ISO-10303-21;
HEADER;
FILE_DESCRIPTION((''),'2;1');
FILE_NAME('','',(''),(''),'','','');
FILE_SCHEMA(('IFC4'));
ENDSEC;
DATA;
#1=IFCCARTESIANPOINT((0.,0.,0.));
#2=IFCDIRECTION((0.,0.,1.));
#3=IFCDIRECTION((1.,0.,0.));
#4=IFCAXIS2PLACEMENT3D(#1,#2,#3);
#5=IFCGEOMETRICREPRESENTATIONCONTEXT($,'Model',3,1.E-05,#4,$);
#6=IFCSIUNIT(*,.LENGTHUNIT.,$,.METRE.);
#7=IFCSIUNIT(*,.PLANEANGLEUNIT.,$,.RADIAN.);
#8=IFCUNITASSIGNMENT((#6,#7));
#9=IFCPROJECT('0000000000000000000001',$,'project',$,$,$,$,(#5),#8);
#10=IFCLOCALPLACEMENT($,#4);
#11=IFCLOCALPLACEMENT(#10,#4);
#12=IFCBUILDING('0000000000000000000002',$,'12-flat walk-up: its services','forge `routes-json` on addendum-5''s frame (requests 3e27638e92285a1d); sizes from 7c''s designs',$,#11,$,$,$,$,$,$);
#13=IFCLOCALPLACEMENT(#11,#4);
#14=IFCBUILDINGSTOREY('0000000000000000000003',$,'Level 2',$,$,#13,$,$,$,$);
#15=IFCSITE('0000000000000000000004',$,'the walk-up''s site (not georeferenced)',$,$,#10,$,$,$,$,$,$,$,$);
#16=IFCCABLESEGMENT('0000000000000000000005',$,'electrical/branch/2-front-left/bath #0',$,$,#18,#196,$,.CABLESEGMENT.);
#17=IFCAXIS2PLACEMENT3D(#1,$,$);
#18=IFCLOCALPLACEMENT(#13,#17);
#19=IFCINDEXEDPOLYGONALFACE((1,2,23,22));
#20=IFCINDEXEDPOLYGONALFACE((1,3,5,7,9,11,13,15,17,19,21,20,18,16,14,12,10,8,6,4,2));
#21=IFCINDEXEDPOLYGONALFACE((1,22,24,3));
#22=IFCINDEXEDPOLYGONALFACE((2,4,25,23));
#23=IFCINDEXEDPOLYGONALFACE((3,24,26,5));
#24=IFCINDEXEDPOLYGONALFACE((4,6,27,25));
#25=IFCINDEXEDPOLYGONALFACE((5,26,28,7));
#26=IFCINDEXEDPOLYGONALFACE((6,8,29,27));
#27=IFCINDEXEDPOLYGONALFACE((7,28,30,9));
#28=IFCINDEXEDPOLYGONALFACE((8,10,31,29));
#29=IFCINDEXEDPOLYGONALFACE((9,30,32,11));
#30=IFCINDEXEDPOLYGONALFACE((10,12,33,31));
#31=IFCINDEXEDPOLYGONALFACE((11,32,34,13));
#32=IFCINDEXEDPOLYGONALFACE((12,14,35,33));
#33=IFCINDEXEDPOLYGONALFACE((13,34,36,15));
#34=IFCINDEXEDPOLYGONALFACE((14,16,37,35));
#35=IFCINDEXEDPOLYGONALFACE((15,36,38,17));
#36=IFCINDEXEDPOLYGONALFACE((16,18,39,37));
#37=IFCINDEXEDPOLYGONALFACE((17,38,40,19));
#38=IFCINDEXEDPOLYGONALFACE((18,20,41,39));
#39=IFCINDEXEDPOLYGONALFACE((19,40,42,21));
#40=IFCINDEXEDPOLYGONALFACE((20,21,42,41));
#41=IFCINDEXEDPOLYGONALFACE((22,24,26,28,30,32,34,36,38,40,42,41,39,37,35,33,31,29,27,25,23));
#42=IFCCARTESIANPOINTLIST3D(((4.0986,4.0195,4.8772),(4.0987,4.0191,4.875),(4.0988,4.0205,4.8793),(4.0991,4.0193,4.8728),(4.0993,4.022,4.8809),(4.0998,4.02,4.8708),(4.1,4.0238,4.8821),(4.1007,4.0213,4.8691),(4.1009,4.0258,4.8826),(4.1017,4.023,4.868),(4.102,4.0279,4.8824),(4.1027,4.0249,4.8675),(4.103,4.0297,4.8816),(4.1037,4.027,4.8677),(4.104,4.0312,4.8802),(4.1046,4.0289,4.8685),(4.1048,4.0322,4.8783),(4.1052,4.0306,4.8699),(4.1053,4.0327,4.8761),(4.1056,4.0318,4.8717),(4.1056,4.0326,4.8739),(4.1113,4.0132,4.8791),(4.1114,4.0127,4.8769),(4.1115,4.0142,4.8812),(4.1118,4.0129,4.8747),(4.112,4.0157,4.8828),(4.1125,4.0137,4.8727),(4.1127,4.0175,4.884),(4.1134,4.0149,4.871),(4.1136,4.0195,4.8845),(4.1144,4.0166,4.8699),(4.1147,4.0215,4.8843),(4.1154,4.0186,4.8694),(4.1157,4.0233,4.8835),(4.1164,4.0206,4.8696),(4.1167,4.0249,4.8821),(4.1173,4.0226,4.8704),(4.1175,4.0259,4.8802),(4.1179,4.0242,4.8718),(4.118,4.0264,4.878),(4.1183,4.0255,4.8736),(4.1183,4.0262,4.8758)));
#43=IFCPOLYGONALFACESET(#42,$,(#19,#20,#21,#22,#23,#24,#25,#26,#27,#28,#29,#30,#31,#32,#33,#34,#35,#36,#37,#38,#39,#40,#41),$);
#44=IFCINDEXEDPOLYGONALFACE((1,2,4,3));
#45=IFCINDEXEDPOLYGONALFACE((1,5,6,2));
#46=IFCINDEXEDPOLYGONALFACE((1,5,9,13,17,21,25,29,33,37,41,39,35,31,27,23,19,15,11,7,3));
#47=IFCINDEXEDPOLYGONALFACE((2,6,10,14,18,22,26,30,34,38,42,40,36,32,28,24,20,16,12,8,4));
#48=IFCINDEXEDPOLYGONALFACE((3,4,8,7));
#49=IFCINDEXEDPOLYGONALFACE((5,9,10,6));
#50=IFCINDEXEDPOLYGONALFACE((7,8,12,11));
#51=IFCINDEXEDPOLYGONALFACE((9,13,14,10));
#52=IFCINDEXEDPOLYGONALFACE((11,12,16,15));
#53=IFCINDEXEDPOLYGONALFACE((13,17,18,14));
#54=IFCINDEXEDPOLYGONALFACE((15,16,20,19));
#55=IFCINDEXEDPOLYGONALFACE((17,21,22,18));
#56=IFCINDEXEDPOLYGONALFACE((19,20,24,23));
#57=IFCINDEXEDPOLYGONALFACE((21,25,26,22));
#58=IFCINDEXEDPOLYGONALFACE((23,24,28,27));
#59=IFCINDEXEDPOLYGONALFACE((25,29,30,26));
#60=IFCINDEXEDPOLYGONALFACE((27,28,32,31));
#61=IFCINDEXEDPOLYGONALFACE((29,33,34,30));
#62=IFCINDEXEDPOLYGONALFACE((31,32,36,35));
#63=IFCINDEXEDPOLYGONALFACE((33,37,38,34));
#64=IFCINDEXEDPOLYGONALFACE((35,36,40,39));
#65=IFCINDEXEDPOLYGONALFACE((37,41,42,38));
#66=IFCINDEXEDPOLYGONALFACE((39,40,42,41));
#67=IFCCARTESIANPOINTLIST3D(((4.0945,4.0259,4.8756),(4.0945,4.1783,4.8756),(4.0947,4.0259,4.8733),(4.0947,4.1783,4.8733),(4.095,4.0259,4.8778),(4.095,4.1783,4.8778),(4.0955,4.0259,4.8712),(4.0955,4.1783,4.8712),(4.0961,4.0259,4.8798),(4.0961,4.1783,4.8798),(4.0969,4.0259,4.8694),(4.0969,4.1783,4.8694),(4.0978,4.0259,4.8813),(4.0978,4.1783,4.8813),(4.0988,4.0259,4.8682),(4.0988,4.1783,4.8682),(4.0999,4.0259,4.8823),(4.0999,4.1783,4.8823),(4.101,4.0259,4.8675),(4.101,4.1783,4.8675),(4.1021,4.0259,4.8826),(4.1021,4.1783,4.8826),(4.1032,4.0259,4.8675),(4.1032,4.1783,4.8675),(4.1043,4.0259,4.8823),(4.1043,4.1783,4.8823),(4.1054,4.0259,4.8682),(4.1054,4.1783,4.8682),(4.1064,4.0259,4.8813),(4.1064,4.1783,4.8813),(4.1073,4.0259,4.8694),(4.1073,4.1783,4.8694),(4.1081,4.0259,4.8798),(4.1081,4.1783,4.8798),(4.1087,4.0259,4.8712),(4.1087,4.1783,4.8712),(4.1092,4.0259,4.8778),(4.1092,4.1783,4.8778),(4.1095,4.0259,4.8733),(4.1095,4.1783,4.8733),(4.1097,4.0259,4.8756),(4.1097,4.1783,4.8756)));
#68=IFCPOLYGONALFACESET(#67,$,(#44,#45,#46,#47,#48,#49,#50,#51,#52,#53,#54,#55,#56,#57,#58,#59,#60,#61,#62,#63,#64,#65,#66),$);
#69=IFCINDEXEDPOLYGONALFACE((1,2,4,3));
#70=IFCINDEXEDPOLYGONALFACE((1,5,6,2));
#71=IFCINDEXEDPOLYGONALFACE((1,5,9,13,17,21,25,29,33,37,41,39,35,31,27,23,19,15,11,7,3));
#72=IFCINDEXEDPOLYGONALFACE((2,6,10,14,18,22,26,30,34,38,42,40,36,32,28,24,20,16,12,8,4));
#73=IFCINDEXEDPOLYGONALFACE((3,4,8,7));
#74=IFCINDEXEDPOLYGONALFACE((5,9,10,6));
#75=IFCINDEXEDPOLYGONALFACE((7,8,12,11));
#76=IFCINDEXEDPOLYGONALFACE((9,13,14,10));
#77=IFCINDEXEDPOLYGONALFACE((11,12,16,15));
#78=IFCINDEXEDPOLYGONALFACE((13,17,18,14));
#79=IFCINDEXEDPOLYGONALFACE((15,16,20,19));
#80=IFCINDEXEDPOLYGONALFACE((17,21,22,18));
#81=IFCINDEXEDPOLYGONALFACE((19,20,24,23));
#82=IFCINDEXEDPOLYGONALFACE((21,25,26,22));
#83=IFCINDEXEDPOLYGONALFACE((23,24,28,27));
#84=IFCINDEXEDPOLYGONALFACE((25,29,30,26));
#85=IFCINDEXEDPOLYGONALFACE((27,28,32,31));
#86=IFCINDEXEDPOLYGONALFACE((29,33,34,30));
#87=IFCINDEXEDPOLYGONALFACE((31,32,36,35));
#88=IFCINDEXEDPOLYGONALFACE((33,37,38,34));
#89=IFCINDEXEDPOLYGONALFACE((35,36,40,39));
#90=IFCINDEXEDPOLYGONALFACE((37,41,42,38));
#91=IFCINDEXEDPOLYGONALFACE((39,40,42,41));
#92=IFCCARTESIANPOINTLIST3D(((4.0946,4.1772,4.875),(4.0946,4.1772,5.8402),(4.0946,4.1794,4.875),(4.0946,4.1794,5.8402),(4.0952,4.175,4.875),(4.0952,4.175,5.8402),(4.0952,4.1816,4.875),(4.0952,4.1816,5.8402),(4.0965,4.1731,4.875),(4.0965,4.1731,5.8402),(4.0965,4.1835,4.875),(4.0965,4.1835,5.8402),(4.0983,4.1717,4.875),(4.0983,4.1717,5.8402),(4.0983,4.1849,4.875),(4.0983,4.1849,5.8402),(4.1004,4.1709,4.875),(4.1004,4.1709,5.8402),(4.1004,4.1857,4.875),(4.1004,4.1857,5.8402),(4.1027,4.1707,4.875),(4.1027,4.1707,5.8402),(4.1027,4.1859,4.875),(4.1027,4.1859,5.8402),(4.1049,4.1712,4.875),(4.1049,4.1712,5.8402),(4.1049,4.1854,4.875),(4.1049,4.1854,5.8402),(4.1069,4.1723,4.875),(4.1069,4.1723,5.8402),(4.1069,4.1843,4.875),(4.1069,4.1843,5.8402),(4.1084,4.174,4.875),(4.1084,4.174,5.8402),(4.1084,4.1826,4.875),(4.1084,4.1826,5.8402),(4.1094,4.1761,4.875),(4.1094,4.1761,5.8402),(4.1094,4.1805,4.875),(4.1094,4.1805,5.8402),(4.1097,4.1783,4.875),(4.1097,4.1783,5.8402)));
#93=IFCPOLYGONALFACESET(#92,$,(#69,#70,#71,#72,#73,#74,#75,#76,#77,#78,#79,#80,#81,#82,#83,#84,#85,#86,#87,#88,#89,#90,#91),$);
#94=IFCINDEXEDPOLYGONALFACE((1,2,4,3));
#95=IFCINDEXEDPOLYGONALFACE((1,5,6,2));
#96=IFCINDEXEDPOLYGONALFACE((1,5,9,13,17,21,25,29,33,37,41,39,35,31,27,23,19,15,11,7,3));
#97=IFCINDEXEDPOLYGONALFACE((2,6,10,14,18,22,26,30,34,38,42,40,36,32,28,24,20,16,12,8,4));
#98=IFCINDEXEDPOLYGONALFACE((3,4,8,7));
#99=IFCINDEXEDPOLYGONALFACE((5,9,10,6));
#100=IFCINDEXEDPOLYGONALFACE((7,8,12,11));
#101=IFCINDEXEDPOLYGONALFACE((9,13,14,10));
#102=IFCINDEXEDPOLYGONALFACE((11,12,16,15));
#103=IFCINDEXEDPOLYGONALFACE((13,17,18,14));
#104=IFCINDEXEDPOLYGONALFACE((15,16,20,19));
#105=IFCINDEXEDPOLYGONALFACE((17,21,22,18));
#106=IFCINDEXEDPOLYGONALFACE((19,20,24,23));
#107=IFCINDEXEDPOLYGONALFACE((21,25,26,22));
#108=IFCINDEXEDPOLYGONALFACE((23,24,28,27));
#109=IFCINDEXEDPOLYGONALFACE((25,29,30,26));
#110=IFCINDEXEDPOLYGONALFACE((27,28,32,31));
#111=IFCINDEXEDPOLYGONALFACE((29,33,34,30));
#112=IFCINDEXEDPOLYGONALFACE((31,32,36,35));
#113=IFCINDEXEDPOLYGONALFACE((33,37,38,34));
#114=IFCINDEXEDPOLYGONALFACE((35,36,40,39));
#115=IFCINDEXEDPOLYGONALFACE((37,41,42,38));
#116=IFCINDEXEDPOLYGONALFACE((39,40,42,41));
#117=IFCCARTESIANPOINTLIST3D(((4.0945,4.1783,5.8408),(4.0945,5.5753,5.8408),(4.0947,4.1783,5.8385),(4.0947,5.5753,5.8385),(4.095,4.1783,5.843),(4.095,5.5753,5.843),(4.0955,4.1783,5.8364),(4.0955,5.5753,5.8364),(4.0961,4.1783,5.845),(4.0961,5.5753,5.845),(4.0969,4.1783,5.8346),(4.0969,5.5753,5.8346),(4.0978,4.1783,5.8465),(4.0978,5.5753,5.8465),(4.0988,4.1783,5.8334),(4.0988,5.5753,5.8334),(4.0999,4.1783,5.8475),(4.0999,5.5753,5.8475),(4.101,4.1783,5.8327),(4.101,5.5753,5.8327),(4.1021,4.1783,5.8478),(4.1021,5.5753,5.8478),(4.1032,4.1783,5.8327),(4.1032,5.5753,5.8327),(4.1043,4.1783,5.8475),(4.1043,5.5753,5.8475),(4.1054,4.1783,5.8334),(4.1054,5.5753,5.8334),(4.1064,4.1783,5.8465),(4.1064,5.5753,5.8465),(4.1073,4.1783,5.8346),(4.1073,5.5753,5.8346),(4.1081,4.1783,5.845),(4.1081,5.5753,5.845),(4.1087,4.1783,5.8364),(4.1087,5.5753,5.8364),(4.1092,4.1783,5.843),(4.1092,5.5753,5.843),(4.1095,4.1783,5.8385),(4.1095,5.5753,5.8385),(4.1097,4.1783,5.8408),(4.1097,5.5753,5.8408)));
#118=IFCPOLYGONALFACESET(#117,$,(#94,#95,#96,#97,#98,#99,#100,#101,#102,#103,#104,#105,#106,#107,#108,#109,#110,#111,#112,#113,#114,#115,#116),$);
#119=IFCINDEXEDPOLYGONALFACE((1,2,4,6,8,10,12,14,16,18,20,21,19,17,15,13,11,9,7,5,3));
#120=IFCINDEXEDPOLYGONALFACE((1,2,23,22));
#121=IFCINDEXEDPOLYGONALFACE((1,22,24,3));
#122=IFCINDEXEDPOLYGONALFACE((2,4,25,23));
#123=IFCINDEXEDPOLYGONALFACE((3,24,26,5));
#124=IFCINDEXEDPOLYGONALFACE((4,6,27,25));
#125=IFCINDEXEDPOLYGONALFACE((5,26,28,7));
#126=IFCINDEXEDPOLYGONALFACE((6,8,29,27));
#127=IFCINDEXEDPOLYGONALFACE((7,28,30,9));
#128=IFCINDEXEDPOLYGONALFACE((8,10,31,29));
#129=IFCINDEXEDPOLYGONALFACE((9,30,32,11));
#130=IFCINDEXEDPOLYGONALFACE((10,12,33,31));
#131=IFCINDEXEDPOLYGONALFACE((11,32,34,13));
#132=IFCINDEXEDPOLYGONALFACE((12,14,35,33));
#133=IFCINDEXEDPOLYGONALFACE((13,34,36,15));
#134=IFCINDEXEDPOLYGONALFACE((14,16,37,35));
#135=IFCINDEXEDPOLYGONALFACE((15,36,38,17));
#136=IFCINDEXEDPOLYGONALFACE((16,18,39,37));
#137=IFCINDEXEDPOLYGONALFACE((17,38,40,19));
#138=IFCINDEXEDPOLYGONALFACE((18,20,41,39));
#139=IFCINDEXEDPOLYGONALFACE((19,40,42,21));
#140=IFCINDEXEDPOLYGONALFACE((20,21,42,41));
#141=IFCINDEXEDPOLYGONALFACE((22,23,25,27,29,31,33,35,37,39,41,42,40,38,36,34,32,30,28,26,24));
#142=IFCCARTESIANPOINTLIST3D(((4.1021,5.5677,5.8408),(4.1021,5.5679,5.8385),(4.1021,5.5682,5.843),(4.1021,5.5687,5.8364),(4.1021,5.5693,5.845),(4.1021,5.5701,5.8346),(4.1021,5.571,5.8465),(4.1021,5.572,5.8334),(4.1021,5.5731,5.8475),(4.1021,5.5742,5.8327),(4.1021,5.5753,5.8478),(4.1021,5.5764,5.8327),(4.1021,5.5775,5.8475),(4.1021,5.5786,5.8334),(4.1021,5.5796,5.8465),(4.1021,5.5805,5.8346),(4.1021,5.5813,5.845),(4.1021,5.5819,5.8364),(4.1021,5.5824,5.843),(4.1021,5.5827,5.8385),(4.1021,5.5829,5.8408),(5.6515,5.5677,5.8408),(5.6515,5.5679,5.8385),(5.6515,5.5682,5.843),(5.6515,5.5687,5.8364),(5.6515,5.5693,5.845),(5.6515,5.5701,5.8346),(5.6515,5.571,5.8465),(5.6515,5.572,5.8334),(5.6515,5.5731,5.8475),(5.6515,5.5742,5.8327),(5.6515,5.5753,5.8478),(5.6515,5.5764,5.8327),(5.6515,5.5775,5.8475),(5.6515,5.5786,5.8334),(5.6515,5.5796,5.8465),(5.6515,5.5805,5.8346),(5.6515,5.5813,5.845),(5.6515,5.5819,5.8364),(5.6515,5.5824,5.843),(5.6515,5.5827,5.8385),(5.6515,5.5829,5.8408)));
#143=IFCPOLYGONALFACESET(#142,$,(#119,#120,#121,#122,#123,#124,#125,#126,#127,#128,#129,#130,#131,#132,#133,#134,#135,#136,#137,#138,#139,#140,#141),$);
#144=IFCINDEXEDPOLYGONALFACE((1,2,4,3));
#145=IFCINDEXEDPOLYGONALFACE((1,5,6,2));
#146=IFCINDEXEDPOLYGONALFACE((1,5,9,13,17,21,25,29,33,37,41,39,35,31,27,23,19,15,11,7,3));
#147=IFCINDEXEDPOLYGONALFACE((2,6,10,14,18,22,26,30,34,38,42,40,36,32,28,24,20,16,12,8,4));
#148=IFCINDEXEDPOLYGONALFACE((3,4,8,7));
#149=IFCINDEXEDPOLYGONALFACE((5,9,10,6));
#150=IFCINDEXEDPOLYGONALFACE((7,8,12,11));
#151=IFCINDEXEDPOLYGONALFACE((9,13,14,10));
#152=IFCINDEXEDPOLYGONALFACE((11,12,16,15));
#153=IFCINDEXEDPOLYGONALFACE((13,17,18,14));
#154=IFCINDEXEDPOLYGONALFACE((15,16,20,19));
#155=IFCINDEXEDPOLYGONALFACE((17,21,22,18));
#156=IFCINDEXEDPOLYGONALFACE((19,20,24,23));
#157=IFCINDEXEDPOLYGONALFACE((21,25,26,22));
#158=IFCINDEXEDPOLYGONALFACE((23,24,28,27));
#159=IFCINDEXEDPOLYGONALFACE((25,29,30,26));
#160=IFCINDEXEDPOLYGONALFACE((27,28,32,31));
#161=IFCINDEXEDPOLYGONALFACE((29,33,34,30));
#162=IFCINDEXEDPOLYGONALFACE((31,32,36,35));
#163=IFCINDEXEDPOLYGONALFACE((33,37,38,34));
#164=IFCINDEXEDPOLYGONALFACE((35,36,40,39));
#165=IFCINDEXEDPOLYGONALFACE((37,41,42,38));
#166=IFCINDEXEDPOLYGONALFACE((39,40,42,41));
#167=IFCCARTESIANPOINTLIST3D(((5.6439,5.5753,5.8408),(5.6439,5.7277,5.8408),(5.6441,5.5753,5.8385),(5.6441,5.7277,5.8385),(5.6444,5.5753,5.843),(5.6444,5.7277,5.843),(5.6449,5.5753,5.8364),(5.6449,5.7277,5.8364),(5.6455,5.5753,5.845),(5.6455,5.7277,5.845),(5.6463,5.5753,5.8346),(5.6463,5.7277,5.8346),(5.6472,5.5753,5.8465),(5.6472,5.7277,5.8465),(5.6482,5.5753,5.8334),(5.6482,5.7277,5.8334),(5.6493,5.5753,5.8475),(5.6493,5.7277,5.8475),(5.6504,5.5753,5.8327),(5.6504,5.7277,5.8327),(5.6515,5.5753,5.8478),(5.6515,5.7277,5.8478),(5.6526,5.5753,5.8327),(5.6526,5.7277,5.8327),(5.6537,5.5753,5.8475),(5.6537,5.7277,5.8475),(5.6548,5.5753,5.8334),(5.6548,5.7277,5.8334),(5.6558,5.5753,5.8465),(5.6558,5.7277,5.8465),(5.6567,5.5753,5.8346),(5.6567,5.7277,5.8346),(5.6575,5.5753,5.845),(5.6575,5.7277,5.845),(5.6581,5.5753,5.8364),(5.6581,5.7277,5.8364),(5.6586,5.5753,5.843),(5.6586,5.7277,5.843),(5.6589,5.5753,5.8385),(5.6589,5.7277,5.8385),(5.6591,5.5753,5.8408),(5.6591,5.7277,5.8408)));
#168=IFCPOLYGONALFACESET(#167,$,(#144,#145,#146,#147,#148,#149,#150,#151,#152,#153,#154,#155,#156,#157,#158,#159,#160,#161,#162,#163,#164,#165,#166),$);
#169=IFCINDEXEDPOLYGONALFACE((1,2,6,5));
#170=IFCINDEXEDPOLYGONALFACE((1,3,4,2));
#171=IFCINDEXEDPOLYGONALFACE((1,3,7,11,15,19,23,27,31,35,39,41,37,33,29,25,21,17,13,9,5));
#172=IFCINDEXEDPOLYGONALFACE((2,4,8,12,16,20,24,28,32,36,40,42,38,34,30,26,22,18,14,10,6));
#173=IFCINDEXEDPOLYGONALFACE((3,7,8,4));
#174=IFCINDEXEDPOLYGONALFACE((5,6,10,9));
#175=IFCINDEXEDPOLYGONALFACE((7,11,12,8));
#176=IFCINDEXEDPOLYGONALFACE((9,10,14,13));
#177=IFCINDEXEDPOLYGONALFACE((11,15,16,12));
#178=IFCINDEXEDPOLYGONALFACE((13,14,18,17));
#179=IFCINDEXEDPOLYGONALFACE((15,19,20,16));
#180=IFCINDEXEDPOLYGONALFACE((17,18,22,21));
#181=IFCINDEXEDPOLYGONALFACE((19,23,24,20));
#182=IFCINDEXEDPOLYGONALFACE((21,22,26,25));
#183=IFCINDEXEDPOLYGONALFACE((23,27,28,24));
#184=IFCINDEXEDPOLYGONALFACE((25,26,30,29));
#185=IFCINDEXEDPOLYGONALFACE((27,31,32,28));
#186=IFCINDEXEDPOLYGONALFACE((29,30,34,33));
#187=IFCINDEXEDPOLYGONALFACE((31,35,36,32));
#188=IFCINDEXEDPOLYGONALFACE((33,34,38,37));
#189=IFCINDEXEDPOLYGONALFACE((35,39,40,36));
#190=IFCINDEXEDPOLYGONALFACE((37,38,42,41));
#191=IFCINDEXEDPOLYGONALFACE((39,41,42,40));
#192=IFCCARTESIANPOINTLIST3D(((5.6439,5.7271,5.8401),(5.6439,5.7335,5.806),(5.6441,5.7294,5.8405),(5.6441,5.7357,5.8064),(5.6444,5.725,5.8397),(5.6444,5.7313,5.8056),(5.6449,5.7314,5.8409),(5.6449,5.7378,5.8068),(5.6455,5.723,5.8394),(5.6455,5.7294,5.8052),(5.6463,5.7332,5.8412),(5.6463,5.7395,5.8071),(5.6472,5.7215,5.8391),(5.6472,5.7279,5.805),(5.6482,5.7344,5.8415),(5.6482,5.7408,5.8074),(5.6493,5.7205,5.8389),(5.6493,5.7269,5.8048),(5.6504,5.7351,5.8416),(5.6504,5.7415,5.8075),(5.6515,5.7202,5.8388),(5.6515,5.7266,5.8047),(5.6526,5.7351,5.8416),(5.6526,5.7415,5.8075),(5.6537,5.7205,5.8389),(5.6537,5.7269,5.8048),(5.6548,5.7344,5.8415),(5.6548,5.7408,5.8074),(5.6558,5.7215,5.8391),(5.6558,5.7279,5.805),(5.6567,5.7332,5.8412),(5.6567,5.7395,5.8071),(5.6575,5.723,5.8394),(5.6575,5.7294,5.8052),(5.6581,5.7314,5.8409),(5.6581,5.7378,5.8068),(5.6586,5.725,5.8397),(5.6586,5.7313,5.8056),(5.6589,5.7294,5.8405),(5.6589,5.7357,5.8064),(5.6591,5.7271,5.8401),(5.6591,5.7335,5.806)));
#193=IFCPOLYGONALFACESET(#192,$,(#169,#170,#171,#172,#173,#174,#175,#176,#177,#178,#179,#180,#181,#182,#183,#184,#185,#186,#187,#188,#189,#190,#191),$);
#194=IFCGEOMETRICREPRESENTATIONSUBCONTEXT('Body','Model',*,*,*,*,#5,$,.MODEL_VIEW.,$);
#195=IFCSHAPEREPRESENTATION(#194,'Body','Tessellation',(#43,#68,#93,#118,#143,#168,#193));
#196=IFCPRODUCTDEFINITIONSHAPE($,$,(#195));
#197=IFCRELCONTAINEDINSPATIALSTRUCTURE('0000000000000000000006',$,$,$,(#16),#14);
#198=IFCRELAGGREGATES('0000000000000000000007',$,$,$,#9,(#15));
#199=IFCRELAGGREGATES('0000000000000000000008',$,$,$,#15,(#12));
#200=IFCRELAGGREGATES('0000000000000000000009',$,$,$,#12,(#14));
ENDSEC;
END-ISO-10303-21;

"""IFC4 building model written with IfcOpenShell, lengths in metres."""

from ifc_helpers import new_model, entity, si_unit, frame, origin_with_axes, place, context, subcontext, project, spatial, element, save


model = new_model("IFC4")

# Units and contexts
model_context = context("Model", 3, precision=1e-05, world=origin_with_axes())
body_context = subcontext(model_context, "Body", "Model", "MODEL_VIEW")
ifc_project = project(units=[si_unit("LENGTHUNIT", "METRE"), si_unit("PLANEANGLEUNIT", "RADIAN")], contexts=[model_context])

# Site, building, storey
site_placement = place(None, origin_with_axes())
site = spatial("IfcSite", under=ifc_project, at=site_placement, Name="the walk-up's site (not georeferenced)")
building_placement = place(site_placement, origin_with_axes())
building = spatial("IfcBuilding", under=site, at=building_placement, Name="12-flat walk-up: its services", Description="forge `routes-json` on addendum-5's frame (requests 3e27638e92285a1d); sizes from 7c's designs")
storey_placement = place(building_placement, origin_with_axes())
storey = spatial("IfcBuildingStorey", under=building, at=storey_placement, Name="Level 2")

# Cable segment
cable_segment_1_placement = place(storey_placement, frame((4.1148, 4.0195, 4.8769), z_axis=(0.0, 0.0, 1.0), x_axis=(1.0, 0.0, 0.0)))
element("IfcCableSegment", 1, at=cable_segment_1_placement, inside=storey, Name="electrical/branch/2-front-left/bath #0", PredefinedType="CABLESEGMENT", context=body_context, shape_type="AdvancedSweptSolid", body=[
    entity("IfcSweptDiskSolid", entity("IfcPolyline", [entity("IfcCartesianPoint", [0.0, 0.0, 0.0]), entity("IfcCartesianPoint", [-0.0127, 0.0064, -0.0019])]), 0.0076),
    entity("IfcSweptDiskSolid", entity("IfcPolyline", [entity("IfcCartesianPoint", [-0.0127, 0.0064, -0.0019]), entity("IfcCartesianPoint", [-0.0127, 0.1588, -0.0019])]), 0.0076),
    entity("IfcSweptDiskSolid", entity("IfcPolyline", [entity("IfcCartesianPoint", [-0.0127, 0.1588, -0.0019]), entity("IfcCartesianPoint", [-0.0127, 0.1588, 0.9633])]), 0.0076),
    entity("IfcSweptDiskSolid", entity("IfcPolyline", [entity("IfcCartesianPoint", [-0.0127, 0.1588, 0.9633]), entity("IfcCartesianPoint", [-0.0127, 1.5557, 0.9633])]), 0.0076),
    entity("IfcSweptDiskSolid", entity("IfcPolyline", [entity("IfcCartesianPoint", [-0.0127, 1.5557, 0.9633]), entity("IfcCartesianPoint", [1.5367, 1.5557, 0.9633])]), 0.0076),
    entity("IfcSweptDiskSolid", entity("IfcPolyline", [entity("IfcCartesianPoint", [1.5367, 1.5557, 0.9633]), entity("IfcCartesianPoint", [1.5367, 1.7081, 0.9633])]), 0.0076),
    entity("IfcSweptDiskSolid", entity("IfcPolyline", [entity("IfcCartesianPoint", [1.5367, 1.7081, 0.9633]), entity("IfcCartesianPoint", [1.5367, 1.7145, 0.9292])]), 0.0076),
])

save(model, "model.ifc")
